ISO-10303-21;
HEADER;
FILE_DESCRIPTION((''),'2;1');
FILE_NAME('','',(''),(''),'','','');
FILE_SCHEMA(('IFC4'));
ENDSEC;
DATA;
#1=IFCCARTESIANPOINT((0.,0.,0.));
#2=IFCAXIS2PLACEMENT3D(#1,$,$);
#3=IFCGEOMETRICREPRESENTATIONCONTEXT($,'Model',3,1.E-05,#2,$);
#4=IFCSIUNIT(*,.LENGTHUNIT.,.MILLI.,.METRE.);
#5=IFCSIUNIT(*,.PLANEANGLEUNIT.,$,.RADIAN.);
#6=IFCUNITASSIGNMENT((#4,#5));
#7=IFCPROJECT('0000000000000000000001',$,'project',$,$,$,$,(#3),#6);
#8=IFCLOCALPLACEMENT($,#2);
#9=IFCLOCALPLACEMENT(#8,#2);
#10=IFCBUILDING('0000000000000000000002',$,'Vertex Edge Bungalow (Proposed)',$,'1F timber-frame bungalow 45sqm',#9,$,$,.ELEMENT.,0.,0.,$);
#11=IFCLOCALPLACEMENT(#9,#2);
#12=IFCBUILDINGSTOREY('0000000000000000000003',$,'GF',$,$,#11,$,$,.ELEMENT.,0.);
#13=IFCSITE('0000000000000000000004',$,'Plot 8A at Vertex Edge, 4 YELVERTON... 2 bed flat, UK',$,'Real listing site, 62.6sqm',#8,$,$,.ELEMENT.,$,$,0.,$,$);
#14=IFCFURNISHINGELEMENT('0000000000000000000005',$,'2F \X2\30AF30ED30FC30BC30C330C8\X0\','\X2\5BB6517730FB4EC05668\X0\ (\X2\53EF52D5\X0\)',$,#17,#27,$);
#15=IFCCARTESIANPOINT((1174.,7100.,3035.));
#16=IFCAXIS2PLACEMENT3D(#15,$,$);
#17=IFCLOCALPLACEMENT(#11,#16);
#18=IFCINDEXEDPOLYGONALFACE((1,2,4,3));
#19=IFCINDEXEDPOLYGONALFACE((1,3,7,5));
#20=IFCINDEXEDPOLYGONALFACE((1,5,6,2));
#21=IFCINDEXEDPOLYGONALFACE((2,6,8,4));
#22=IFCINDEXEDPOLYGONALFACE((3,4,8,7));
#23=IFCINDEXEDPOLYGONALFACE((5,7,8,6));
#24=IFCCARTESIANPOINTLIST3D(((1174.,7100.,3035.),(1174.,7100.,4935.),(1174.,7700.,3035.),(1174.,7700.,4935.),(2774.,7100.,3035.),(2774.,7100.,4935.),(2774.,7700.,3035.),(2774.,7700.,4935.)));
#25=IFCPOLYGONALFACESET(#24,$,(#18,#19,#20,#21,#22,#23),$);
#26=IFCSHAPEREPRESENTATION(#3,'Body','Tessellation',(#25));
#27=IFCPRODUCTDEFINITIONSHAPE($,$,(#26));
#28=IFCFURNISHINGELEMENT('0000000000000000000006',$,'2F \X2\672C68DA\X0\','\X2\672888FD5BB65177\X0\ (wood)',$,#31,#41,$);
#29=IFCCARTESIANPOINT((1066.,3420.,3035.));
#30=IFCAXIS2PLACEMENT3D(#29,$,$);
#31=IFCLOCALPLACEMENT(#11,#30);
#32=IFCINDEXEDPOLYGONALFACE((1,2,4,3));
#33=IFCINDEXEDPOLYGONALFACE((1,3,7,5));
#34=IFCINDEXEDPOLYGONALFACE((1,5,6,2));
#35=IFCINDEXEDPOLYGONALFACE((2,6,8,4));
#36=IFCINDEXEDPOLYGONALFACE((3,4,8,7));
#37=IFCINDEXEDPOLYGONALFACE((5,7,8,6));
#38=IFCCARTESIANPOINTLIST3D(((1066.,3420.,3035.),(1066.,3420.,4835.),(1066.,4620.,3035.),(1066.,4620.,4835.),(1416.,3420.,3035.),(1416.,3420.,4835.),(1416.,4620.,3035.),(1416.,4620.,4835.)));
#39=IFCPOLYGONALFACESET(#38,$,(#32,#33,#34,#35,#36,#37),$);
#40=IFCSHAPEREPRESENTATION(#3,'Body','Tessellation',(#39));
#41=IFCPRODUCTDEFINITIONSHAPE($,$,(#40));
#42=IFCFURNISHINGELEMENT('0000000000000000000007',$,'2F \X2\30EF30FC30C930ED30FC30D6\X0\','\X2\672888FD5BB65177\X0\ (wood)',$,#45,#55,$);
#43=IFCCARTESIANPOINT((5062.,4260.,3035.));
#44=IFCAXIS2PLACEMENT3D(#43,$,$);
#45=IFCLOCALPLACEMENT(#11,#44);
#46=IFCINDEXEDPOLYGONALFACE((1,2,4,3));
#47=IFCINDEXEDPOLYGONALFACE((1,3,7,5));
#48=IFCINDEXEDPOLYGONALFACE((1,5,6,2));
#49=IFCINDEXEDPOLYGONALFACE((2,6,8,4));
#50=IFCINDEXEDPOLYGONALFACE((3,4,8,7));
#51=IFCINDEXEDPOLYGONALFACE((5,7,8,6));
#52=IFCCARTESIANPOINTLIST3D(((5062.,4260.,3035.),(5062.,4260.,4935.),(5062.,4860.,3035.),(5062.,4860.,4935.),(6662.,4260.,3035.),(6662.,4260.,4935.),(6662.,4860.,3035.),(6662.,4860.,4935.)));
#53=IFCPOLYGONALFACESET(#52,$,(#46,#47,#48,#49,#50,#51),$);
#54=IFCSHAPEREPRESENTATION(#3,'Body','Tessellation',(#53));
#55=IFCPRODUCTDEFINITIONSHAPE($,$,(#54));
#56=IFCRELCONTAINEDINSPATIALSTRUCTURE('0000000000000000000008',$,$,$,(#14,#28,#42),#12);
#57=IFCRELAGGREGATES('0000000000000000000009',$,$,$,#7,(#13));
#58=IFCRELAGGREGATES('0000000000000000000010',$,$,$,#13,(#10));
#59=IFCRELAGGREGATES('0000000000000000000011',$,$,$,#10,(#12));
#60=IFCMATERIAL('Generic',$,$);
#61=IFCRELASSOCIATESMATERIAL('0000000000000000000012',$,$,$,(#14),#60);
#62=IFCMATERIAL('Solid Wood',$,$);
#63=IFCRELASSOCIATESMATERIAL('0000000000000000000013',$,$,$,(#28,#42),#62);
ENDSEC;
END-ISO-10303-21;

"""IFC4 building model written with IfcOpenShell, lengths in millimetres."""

from ifc_helpers import new_model, si_unit, frame, frame_2d, origin, place, context, project, spatial, rectangle, extrude, material, element, save


model = new_model("IFC4")

# Units and contexts
model_context = context("Model", 3, precision=1e-05, world=origin())
ifc_project = project(units=[si_unit("LENGTHUNIT", "METRE", prefix="MILLI"), si_unit("PLANEANGLEUNIT", "RADIAN")], contexts=[model_context])

# Site, building, storey
site_placement = place(None, origin())
site = spatial("IfcSite", under=ifc_project, at=site_placement, Name="Plot 8A at Vertex Edge, 4 YELVERTON... 2 bed flat, UK", ObjectType="Real listing site, 62.6sqm", CompositionType="ELEMENT", RefElevation=0.0)
building_placement = place(site_placement, origin())
building = spatial("IfcBuilding", under=site, at=building_placement, Name="Vertex Edge Bungalow (Proposed)", ObjectType="1F timber-frame bungalow 45sqm", CompositionType="ELEMENT", ElevationOfRefHeight=0.0, ElevationOfTerrain=0.0)
storey_placement = place(building_placement, origin())
storey = spatial("IfcBuildingStorey", under=building, at=storey_placement, Name="GF", CompositionType="ELEMENT", Elevation=0.0)

# Shared definitions
ifc_material_1 = material(Name="Solid Wood")

# Shared definitions
ifc_material_2 = material(Name="Generic")

# Furnishing elements
furnishing_1_placement = place(storey_placement, frame((1174.0, 7100.0, 3035.0)))
element("IfcFurnishingElement", 1, at=furnishing_1_placement, inside=storey, material=ifc_material_2, Name="2F クローゼット", Description="家具・什器 (可動)", context=model_context, shape_type="SweptSolid", body=[
    extrude(rectangle(XDim=1600.0, YDim=600.0, at=frame_2d((800.0, 300.0))), frame((1174.0, 7100.0, 3035.0)), (0.0, 0.0, 1.0), 1900.0),
])
furnishing_2_placement = place(storey_placement, frame((1066.0, 3420.0, 3035.0)))
element("IfcFurnishingElement", 2, at=furnishing_2_placement, inside=storey, material=ifc_material_1, Name="2F 本棚", Description="木製家具 (wood)", context=model_context, shape_type="SweptSolid", body=[
    extrude(rectangle(XDim=350.0, YDim=1200.0, at=frame_2d((175.0, 600.0))), frame((1066.0, 3420.0, 3035.0)), (0.0, 0.0, 1.0), 1800.0),
])
furnishing_3_placement = place(storey_placement, frame((5062.0, 4260.0, 3035.0)))
element("IfcFurnishingElement", 3, at=furnishing_3_placement, inside=storey, material=ifc_material_1, Name="2F ワードローブ", Description="木製家具 (wood)", context=model_context, shape_type="SweptSolid", body=[
    extrude(rectangle(XDim=1600.0, YDim=600.0, at=frame_2d((800.0, 300.0))), frame((5062.0, 4260.0, 3035.0)), (0.0, 0.0, 1.0), 1900.0),
])

save(model, "model.ifc")
